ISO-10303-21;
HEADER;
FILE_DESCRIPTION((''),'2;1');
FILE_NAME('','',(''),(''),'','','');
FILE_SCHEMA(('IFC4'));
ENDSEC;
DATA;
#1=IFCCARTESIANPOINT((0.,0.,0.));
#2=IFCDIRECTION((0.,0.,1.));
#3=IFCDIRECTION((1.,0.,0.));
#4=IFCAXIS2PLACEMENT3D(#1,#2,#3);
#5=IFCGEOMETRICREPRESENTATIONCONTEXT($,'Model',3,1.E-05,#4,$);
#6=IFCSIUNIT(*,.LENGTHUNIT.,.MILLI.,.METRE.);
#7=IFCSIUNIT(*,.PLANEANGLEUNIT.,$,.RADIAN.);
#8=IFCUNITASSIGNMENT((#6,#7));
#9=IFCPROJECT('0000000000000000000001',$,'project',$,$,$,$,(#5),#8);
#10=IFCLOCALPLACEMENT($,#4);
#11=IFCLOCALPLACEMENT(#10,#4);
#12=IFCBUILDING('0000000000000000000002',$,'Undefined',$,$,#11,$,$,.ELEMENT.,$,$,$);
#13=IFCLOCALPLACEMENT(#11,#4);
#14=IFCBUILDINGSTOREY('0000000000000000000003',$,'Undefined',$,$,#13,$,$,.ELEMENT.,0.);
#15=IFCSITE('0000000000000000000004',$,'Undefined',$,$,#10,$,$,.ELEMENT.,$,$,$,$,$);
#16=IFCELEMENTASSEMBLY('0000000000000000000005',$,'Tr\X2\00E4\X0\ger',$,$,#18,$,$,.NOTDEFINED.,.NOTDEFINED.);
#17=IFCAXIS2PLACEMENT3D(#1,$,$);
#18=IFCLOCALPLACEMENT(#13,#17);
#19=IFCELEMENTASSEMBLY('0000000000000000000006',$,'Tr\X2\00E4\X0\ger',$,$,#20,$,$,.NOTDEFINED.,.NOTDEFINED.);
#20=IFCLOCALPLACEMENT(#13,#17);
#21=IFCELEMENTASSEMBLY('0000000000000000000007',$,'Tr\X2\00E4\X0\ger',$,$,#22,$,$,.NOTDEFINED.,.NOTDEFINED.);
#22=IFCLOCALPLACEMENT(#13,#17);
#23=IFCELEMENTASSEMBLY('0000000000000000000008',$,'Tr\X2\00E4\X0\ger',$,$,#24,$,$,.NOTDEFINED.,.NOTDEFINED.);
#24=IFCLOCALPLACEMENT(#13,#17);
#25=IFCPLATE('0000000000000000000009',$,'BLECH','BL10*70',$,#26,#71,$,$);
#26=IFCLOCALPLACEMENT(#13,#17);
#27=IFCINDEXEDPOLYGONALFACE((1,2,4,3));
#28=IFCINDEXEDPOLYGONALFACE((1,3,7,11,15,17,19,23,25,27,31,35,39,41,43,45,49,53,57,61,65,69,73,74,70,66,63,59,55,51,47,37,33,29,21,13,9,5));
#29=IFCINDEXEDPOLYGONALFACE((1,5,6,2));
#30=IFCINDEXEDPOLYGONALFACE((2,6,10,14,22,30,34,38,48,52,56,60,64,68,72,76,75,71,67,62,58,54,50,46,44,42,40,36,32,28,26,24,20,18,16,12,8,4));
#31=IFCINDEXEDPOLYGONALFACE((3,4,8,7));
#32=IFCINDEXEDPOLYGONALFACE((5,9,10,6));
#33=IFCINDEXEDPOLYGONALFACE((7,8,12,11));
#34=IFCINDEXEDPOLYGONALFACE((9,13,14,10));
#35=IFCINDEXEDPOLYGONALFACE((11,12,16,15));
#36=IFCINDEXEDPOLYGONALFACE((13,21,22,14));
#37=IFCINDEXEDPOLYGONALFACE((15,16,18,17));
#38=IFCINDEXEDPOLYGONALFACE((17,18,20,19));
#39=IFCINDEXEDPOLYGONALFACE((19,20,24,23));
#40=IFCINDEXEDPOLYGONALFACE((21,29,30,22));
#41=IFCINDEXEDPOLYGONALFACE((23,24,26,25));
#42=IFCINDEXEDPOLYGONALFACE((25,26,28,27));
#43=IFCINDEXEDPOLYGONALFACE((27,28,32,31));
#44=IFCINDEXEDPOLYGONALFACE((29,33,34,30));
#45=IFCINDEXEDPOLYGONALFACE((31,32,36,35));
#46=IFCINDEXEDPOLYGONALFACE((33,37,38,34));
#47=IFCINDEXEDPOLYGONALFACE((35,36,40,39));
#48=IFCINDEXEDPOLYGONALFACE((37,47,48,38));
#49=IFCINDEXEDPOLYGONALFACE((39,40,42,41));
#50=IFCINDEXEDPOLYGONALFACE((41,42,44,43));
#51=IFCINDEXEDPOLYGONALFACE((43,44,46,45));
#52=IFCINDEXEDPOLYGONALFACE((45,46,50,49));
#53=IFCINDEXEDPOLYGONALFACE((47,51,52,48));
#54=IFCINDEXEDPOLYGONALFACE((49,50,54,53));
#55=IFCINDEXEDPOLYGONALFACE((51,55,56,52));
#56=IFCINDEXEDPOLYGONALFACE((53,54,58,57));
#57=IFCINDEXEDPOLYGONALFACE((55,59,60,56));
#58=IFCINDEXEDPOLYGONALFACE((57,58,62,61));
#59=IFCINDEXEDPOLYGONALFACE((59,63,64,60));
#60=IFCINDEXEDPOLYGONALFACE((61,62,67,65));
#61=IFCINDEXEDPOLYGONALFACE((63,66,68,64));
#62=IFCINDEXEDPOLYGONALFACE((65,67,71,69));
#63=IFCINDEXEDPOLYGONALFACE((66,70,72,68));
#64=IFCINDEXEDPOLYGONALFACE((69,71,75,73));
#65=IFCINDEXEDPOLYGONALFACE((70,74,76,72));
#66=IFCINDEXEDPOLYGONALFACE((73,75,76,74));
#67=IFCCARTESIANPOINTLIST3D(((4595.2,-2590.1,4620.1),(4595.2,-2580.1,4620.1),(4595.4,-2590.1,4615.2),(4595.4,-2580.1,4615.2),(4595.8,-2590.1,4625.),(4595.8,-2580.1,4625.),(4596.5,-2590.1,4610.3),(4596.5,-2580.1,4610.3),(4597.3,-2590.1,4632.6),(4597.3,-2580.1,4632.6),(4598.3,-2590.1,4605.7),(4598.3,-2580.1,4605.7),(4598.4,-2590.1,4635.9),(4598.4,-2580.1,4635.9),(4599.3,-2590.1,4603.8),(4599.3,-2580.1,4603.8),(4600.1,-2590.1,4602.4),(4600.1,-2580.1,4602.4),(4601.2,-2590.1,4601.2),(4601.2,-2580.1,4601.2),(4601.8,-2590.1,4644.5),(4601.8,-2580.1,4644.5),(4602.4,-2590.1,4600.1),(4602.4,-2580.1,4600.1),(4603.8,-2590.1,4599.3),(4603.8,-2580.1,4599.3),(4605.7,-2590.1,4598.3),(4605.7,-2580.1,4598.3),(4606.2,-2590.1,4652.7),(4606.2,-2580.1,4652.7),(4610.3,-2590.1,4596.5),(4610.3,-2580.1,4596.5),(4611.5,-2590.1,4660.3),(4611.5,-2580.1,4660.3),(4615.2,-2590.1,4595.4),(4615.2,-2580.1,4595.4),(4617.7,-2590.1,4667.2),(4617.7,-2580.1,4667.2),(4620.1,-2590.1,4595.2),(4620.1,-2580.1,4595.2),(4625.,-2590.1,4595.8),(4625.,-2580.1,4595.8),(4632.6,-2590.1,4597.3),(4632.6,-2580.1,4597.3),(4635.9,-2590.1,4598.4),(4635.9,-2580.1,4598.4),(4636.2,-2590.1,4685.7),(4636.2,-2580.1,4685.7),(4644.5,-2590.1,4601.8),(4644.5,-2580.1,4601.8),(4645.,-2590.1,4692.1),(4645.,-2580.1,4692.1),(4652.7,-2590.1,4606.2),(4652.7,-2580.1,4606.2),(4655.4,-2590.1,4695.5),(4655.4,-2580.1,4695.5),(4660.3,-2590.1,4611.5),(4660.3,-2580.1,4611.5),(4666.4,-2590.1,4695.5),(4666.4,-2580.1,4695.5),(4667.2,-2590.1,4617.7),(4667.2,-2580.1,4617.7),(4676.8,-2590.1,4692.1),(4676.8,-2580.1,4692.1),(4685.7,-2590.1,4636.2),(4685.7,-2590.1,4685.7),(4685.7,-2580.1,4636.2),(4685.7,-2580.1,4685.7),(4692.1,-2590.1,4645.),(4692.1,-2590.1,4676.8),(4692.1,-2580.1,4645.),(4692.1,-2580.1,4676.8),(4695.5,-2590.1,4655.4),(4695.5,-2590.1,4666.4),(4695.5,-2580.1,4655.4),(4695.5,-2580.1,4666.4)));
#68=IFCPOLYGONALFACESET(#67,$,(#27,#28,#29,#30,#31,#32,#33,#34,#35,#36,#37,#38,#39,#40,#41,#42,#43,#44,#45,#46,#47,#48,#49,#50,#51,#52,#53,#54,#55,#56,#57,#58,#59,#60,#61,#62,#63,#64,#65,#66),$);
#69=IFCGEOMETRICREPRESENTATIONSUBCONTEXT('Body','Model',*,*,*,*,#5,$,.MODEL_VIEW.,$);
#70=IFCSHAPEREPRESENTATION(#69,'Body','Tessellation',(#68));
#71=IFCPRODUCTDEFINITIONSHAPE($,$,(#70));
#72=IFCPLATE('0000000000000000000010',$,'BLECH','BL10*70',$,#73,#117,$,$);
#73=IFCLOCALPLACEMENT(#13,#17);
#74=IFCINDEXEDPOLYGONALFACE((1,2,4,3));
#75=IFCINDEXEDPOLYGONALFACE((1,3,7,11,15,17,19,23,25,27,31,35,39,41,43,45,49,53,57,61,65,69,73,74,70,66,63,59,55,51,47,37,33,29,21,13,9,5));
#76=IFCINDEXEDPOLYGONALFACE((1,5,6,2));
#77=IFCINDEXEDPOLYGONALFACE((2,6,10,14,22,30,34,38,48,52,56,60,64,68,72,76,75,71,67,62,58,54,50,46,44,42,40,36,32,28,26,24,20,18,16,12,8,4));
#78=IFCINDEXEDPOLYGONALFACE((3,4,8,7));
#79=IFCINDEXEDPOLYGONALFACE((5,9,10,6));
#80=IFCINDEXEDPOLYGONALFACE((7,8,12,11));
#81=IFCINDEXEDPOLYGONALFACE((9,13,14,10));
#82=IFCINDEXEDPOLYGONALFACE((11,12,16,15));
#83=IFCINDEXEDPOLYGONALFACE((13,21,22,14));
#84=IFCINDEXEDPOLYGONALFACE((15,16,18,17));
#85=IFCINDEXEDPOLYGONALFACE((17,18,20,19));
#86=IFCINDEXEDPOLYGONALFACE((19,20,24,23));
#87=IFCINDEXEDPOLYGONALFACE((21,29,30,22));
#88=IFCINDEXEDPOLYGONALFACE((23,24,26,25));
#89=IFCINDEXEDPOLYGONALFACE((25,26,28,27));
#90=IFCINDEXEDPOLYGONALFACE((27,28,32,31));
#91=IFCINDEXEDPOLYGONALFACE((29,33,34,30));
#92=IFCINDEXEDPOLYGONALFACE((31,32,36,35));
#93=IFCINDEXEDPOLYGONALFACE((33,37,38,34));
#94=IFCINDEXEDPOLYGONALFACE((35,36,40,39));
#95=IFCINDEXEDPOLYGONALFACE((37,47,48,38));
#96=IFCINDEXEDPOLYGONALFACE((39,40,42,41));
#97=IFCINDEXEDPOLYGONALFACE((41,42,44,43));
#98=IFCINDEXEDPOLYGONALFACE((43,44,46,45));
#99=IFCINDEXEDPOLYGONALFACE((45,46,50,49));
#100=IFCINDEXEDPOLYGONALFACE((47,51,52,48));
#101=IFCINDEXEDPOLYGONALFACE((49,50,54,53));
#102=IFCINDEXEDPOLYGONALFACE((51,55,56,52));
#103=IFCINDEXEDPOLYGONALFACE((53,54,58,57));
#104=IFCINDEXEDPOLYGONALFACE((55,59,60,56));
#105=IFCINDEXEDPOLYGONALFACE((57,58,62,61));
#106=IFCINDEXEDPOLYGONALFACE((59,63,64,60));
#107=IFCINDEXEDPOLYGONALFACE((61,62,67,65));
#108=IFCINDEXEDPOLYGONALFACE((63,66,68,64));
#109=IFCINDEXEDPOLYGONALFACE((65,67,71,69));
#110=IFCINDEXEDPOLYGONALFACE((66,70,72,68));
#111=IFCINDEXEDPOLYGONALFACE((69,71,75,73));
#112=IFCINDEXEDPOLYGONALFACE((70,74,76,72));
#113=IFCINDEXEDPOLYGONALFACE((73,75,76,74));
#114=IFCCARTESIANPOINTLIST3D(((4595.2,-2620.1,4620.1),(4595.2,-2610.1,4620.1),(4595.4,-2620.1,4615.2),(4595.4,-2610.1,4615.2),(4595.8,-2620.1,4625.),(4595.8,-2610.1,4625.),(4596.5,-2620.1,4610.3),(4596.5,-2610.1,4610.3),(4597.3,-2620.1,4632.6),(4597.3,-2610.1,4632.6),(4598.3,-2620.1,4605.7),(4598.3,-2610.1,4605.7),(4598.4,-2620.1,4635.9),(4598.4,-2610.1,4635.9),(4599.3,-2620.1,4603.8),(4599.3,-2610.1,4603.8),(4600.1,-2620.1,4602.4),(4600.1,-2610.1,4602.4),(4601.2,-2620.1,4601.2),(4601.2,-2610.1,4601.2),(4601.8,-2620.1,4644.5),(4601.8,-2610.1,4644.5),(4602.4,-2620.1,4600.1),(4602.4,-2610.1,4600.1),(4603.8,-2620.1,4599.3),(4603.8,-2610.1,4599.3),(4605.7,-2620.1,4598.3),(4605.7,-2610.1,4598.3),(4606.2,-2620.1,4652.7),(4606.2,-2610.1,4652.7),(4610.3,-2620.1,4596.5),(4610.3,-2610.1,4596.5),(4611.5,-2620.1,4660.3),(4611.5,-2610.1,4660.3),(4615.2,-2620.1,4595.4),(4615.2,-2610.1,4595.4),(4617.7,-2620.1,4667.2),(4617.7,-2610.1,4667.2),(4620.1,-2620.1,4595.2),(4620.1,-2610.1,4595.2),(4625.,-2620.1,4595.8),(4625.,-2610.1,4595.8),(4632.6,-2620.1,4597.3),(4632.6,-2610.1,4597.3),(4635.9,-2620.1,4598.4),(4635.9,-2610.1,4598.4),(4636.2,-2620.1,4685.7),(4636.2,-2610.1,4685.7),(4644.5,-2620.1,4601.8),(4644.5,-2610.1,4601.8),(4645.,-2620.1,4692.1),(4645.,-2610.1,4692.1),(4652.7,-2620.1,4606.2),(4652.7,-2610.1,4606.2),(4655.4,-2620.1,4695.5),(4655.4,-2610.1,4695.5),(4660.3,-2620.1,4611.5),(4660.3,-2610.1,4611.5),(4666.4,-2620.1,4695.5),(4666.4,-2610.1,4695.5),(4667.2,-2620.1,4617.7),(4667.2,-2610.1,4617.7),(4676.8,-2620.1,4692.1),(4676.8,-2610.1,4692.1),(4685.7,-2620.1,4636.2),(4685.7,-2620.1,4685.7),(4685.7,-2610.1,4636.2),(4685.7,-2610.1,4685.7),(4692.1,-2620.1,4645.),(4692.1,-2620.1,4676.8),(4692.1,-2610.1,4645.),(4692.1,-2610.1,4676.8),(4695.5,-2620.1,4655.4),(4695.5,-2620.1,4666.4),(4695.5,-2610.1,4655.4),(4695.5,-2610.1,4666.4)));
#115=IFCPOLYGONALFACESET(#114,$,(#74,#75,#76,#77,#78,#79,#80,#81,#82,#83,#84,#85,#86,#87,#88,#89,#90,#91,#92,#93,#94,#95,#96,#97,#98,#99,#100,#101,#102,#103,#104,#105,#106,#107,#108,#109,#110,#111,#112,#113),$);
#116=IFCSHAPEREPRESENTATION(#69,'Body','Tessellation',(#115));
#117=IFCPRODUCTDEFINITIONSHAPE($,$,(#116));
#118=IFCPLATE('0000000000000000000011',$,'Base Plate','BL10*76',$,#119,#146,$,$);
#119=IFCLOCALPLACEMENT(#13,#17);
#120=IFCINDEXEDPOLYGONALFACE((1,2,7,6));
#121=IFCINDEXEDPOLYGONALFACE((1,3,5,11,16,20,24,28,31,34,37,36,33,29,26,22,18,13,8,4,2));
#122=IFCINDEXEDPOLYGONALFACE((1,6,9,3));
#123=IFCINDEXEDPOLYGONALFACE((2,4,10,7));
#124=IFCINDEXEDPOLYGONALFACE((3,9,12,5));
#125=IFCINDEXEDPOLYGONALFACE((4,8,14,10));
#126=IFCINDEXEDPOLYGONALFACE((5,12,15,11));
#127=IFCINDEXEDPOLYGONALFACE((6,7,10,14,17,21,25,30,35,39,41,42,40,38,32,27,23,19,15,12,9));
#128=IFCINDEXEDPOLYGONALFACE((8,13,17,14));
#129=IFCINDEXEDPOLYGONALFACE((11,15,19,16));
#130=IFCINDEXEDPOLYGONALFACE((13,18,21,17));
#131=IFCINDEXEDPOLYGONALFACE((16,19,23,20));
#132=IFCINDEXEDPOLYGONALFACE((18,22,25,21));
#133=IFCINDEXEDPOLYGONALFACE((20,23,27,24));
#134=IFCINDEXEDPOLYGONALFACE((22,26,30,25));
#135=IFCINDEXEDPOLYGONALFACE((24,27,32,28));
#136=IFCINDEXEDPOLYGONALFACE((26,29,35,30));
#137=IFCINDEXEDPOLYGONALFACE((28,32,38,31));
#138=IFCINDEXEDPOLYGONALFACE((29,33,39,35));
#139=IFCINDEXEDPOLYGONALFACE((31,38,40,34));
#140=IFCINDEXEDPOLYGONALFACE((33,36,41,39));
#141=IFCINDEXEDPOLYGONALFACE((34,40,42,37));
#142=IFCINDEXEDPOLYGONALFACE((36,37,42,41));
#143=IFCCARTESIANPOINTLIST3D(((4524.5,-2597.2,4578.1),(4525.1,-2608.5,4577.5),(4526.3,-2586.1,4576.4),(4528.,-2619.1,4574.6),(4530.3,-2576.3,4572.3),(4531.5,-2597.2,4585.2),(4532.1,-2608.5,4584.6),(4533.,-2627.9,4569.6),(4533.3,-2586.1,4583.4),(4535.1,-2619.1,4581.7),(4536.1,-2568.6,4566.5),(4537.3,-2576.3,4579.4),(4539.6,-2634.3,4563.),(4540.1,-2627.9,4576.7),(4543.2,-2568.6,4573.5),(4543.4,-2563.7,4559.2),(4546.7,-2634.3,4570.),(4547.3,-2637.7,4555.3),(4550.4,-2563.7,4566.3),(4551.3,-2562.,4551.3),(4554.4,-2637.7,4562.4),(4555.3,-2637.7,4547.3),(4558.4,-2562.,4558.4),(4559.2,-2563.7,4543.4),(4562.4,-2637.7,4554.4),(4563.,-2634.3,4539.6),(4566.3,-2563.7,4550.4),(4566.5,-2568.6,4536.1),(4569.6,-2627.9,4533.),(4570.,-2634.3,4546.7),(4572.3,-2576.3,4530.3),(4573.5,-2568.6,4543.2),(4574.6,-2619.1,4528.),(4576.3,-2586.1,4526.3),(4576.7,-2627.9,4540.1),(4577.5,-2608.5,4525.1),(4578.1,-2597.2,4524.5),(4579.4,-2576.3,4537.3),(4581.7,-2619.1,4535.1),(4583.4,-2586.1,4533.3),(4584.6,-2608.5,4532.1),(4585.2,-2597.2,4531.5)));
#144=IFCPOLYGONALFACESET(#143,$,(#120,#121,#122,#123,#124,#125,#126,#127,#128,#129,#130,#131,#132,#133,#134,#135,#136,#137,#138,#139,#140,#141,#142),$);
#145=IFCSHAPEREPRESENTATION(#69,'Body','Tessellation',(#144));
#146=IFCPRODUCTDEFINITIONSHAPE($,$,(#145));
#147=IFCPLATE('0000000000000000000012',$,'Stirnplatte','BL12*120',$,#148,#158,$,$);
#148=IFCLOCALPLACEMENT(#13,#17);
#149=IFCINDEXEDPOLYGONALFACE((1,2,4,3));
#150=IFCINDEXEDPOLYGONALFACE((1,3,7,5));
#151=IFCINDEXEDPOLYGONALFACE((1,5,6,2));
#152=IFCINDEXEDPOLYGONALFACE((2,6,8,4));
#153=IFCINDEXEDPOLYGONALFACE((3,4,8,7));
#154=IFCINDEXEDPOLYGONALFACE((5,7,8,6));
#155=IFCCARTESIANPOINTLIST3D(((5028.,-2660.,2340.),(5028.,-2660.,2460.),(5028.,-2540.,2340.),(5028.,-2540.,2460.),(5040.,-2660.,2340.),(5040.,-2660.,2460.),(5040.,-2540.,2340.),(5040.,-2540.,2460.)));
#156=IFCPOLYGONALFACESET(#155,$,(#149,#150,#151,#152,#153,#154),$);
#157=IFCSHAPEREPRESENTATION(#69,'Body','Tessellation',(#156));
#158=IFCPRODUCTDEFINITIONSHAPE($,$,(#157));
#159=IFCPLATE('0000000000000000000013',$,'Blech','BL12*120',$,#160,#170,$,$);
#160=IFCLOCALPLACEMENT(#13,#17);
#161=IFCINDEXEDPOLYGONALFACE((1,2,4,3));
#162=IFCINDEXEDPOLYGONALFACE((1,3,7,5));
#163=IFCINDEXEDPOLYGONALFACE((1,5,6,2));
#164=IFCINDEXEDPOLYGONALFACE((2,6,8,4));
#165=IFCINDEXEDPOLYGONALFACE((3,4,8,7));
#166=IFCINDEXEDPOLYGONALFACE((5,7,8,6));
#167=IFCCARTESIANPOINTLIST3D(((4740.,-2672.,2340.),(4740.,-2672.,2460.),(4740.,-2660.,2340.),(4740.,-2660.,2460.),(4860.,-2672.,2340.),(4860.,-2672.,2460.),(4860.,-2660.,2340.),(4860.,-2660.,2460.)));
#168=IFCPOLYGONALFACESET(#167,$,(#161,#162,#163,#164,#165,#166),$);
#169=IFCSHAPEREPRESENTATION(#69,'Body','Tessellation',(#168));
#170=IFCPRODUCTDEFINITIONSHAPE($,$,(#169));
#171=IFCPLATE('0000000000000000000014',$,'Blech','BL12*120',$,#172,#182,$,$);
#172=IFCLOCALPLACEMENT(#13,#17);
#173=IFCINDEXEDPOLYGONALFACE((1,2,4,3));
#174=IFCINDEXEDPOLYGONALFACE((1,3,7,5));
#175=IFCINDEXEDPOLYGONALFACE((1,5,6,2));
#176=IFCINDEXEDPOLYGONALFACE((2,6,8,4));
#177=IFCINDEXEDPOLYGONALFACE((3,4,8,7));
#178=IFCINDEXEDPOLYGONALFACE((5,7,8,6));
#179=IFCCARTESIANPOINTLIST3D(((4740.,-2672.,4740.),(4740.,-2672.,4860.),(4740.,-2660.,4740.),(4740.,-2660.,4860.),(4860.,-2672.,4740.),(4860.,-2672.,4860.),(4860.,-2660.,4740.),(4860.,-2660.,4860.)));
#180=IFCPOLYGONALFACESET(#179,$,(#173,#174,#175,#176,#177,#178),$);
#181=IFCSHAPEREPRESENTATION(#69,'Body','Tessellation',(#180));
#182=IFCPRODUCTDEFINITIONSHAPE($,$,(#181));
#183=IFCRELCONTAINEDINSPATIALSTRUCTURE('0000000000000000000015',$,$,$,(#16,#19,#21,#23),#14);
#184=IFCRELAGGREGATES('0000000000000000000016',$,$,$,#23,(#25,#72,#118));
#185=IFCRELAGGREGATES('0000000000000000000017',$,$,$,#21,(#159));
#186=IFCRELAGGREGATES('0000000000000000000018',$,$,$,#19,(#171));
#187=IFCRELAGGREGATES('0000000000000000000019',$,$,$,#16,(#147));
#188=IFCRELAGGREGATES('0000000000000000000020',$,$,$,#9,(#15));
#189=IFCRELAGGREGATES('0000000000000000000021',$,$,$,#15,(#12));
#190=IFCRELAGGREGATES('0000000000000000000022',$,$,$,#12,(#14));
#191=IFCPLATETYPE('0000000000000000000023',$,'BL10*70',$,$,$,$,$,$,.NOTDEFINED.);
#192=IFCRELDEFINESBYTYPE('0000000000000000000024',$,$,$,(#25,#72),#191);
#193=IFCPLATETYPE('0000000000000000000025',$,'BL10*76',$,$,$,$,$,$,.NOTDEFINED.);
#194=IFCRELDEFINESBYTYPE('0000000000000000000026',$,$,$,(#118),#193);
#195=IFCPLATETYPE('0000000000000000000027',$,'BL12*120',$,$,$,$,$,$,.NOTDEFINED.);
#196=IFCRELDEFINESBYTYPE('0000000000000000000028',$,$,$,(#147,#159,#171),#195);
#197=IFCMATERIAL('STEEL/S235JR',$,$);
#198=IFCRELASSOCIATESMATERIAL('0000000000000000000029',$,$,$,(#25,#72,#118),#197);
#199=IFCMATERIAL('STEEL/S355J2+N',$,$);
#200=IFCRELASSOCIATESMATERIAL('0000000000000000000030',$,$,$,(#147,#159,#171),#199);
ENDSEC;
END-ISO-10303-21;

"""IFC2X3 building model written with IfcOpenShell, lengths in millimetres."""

from ifc_helpers import new_model, si_unit, frame, frame_2d, origin_with_axes, place, context, subcontext, project, spatial, polyline, circle_curve, parameter, trimmed, segment, composite_curve, outline, extrude, clip, halfspace, material, type_object, element, aggregate, save


model = new_model("IFC2X3")

# Units and contexts
model_context = context("Model", 3, precision=1e-05, world=origin_with_axes())
body_context = subcontext(model_context, "Body", "Model", "MODEL_VIEW")
ifc_project = project(units=[si_unit("LENGTHUNIT", "METRE", prefix="MILLI"), si_unit("PLANEANGLEUNIT", "RADIAN")], contexts=[model_context])

# Site, building, storey
site_placement = place(None, origin_with_axes())
site = spatial("IfcSite", under=ifc_project, at=site_placement, Name="Undefined", CompositionType="ELEMENT")
building_placement = place(site_placement, origin_with_axes())
building = spatial("IfcBuilding", under=site, at=building_placement, Name="Undefined", CompositionType="ELEMENT")
storey_placement = place(building_placement, origin_with_axes())
storey = spatial("IfcBuildingStorey", under=building, at=storey_placement, Name="Undefined", CompositionType="ELEMENT", Elevation=0.0)

# Shared definitions
ifc_material_1 = material(Name="STEEL/S235JR")

# Element assembly
assembly_1_placement = place(storey_placement, origin_with_axes())
assembly_1 = element("IfcElementAssembly", 1, at=assembly_1_placement, inside=storey, Name="Träger", AssemblyPlace="NOTDEFINED", PredefinedType="NOTDEFINED")

# Element assemblies
assembly_2_placement = place(storey_placement, origin_with_axes())
assembly_2 = element("IfcElementAssembly", 2, at=assembly_2_placement, inside=storey, Name="Träger", AssemblyPlace="NOTDEFINED", PredefinedType="NOTDEFINED")
assembly_3_placement = place(storey_placement, origin_with_axes())
assembly_3 = element("IfcElementAssembly", 3, at=assembly_3_placement, inside=storey, Name="Träger", AssemblyPlace="NOTDEFINED", PredefinedType="NOTDEFINED")

# Element assembly, plates
assembly_4_placement = place(storey_placement, origin_with_axes())
assembly_4 = element("IfcElementAssembly", 4, at=assembly_4_placement, inside=storey, Name="Träger", AssemblyPlace="NOTDEFINED", PredefinedType="NOTDEFINED")
plate_type_1 = type_object("IfcPlateType", Name="BL10*70", PredefinedType="NOTDEFINED")
plate_1_placement = place(assembly_4_placement, frame((4604.3, -2585.1, 4653.8), z_axis=(0.0, -1.0, 0.0), x_axis=(-0.316274, 0.0, -0.948668)))
plate_1 = element("IfcPlate", 5, at=plate_1_placement, type_object=plate_type_1, material=ifc_material_1, Name="BLECH", Description="BL10*70", context=body_context, shape_type="SweptSolid", body=[
    extrude(outline(polyline([(-16.9, 8.4), (-8.4, 4.8), (0.5, 2.1), (9.6, 0.5), (18.9, 0.0), (22.4, 0.0), (30.0, 1.0), (34.9, 2.0), (39.5, 3.8), (43.7, 6.3), (47.5, 9.5), (49.1, 11.1), (50.1, 12.3), (50.9, 13.7), (51.5, 15.1), (51.9, 16.7), (52.2, 18.9), (52.5, 23.8), (52.0, 28.7), (50.6, 33.5), (48.6, 38.0), (44.7, 44.7), (42.6, 47.5), (36.6, 54.6), (29.9, 60.9), (22.4, 66.4), (14.4, 71.0), (-9.0, 82.7), (-19.4, 86.0), (-30.3, 86.0), (-40.7, 82.5), (-49.5, 76.0), (-55.9, 67.1), (-55.9, 67.1), (-59.2, 56.6), (-59.1, 45.7), (-55.7, 35.3), (-49.2, 26.5), (-40.3, 20.1), (-16.9, 8.4)])), frame((0.0, 0.0, -5.0), z_axis=(0.0, 0.0, 1.0), x_axis=(1.0, 0.0, 0.0)), (0.0, 0.0, 1.0), 10.0),
])
plate_2_placement = place(assembly_4_placement, frame((4604.3, -2615.1, 4653.8), z_axis=(0.0, -1.0, 0.0), x_axis=(-0.316274, 0.0, -0.948668)))
plate_2 = element("IfcPlate", 6, at=plate_2_placement, type_object=plate_type_1, material=ifc_material_1, Name="BLECH", Description="BL10*70", context=body_context, shape_type="SweptSolid", body=[
    extrude(outline(polyline([(-16.9, 8.4), (-8.4, 4.8), (0.5, 2.1), (9.6, 0.5), (18.9, 0.0), (22.4, 0.0), (30.0, 1.0), (34.9, 2.0), (39.5, 3.8), (43.7, 6.3), (47.5, 9.5), (49.1, 11.1), (50.1, 12.3), (50.9, 13.7), (51.5, 15.1), (51.9, 16.7), (52.2, 18.9), (52.5, 23.8), (52.0, 28.7), (50.6, 33.5), (48.6, 38.0), (44.7, 44.7), (42.6, 47.5), (36.6, 54.6), (29.9, 60.9), (22.4, 66.4), (14.4, 71.0), (-9.0, 82.7), (-19.4, 86.0), (-30.3, 86.0), (-40.7, 82.5), (-49.5, 76.0), (-55.9, 67.1), (-55.9, 67.1), (-59.2, 56.6), (-59.1, 45.7), (-55.7, 35.3), (-49.2, 26.5), (-40.3, 20.1), (-16.9, 8.4)])), frame((0.0, 0.0, -5.0), z_axis=(0.0, 0.0, 1.0), x_axis=(1.0, 0.0, 0.0)), (0.0, 0.0, 1.0), 10.0),
])

# Plates
plate_type_2 = type_object("IfcPlateType", Name="BL10*76", PredefinedType="NOTDEFINED")
plate_3_placement = place(assembly_4_placement, frame((4581.7, -2638.1, 4527.9), z_axis=(-0.707141, 0.0, -0.707072), x_axis=(-0.707072, 0.0, 0.707141)))
plate_3 = element("IfcPlate", 7, at=plate_3_placement, type_object=plate_type_2, material=ifc_material_1, Name="Base Plate", Description="BL10*76", context=body_context, shape_type="Clipping", body=[
    clip(extrude(outline(composite_curve([segment(trimmed(circle_curve(frame_2d((38.0, 38.0), x_axis=(-1.0, 0.0)), 38.0), [parameter(0.0)], [parameter(1.570796)], True, "PARAMETER"), True, "CONTINUOUS"), segment(trimmed(circle_curve(frame_2d((38.0, 38.0), x_axis=(0.0, -1.0)), 38.0), [parameter(0.0)], [parameter(1.570796)], True, "PARAMETER"), True, "CONTINUOUS"), segment(trimmed(circle_curve(frame_2d((38.0, 38.0), x_axis=(1.0, 0.0)), 38.0), [parameter(0.0)], [parameter(1.570796)], True, "PARAMETER"), True, "CONTINUOUS"), segment(trimmed(circle_curve(frame_2d((38.0, 38.0), x_axis=(0.0, 1.0)), 38.0), [parameter(0.0)], [parameter(1.570796)], True, "PARAMETER"), True, "CONTINUOUS")], self_intersect=True)), frame((0.0, 0.0, -5.0), z_axis=(0.0, 0.0, 1.0), x_axis=(1.0, 0.0, 0.0)), (0.0, 0.0, 1.0), 10.0), halfspace(frame((76.1, 0.0, 5.0), z_axis=(0.0, 0.0, -1.0), x_axis=(1.0, 0.0, 0.0)), True)),
])
aggregate(assembly_4, [plate_1, plate_2, plate_3])
ifc_material_2 = material(Name="STEEL/S355J2+N")
plate_type_3 = type_object("IfcPlateType", Name="BL12*120", PredefinedType="NOTDEFINED")
plate_4_placement = place(assembly_1_placement, frame((5034.0, -2600.0, 2340.0), z_axis=(1.0, 0.0, 0.0), x_axis=(0.0, 0.0, 1.0)))
plate_4 = element("IfcPlate", 8, at=plate_4_placement, type_object=plate_type_3, material=ifc_material_2, Name="Stirnplatte", Description="BL12*120", context=body_context, shape_type="SweptSolid", body=[
    extrude(outline(polyline([(0.0, -60.0), (0.0, 60.0), (120.0, 60.0), (120.0, -60.0), (0.0, -60.0)])), frame((0.0, 0.0, -6.0), z_axis=(0.0, 0.0, 1.0), x_axis=(1.0, 0.0, 0.0)), (0.0, 0.0, 1.0), 12.0),
])
plate_5_placement = place(assembly_3_placement, frame((4800.0, -2666.0, 2340.0), z_axis=(0.0, -1.0, 0.0), x_axis=(0.0, 0.0, 1.0)))
plate_5 = element("IfcPlate", 9, at=plate_5_placement, type_object=plate_type_3, material=ifc_material_2, Name="Blech", Description="BL12*120", context=body_context, shape_type="SweptSolid", body=[
    extrude(outline(polyline([(0.0, -60.0), (0.0, 60.0), (120.0, 60.0), (120.0, -60.0), (0.0, -60.0)])), frame((0.0, 0.0, -6.0), z_axis=(0.0, 0.0, 1.0), x_axis=(1.0, 0.0, 0.0)), (0.0, 0.0, 1.0), 12.0),
])
aggregate(assembly_3, [plate_5])
plate_6_placement = place(assembly_2_placement, frame((4800.0, -2666.0, 4740.0), z_axis=(0.0, -1.0, 0.0), x_axis=(0.0, 0.0, 1.0)))
plate_6 = element("IfcPlate", 10, at=plate_6_placement, type_object=plate_type_3, material=ifc_material_2, Name="Blech", Description="BL12*120", context=body_context, shape_type="SweptSolid", body=[
    extrude(outline(polyline([(0.0, -60.0), (0.0, 60.0), (120.0, 60.0), (120.0, -60.0), (0.0, -60.0)])), frame((0.0, 0.0, -6.0), z_axis=(0.0, 0.0, 1.0), x_axis=(1.0, 0.0, 0.0)), (0.0, 0.0, 1.0), 12.0),
])
aggregate(assembly_2, [plate_6])

aggregate(assembly_1, [plate_4])

save(model, "model.ifc")
